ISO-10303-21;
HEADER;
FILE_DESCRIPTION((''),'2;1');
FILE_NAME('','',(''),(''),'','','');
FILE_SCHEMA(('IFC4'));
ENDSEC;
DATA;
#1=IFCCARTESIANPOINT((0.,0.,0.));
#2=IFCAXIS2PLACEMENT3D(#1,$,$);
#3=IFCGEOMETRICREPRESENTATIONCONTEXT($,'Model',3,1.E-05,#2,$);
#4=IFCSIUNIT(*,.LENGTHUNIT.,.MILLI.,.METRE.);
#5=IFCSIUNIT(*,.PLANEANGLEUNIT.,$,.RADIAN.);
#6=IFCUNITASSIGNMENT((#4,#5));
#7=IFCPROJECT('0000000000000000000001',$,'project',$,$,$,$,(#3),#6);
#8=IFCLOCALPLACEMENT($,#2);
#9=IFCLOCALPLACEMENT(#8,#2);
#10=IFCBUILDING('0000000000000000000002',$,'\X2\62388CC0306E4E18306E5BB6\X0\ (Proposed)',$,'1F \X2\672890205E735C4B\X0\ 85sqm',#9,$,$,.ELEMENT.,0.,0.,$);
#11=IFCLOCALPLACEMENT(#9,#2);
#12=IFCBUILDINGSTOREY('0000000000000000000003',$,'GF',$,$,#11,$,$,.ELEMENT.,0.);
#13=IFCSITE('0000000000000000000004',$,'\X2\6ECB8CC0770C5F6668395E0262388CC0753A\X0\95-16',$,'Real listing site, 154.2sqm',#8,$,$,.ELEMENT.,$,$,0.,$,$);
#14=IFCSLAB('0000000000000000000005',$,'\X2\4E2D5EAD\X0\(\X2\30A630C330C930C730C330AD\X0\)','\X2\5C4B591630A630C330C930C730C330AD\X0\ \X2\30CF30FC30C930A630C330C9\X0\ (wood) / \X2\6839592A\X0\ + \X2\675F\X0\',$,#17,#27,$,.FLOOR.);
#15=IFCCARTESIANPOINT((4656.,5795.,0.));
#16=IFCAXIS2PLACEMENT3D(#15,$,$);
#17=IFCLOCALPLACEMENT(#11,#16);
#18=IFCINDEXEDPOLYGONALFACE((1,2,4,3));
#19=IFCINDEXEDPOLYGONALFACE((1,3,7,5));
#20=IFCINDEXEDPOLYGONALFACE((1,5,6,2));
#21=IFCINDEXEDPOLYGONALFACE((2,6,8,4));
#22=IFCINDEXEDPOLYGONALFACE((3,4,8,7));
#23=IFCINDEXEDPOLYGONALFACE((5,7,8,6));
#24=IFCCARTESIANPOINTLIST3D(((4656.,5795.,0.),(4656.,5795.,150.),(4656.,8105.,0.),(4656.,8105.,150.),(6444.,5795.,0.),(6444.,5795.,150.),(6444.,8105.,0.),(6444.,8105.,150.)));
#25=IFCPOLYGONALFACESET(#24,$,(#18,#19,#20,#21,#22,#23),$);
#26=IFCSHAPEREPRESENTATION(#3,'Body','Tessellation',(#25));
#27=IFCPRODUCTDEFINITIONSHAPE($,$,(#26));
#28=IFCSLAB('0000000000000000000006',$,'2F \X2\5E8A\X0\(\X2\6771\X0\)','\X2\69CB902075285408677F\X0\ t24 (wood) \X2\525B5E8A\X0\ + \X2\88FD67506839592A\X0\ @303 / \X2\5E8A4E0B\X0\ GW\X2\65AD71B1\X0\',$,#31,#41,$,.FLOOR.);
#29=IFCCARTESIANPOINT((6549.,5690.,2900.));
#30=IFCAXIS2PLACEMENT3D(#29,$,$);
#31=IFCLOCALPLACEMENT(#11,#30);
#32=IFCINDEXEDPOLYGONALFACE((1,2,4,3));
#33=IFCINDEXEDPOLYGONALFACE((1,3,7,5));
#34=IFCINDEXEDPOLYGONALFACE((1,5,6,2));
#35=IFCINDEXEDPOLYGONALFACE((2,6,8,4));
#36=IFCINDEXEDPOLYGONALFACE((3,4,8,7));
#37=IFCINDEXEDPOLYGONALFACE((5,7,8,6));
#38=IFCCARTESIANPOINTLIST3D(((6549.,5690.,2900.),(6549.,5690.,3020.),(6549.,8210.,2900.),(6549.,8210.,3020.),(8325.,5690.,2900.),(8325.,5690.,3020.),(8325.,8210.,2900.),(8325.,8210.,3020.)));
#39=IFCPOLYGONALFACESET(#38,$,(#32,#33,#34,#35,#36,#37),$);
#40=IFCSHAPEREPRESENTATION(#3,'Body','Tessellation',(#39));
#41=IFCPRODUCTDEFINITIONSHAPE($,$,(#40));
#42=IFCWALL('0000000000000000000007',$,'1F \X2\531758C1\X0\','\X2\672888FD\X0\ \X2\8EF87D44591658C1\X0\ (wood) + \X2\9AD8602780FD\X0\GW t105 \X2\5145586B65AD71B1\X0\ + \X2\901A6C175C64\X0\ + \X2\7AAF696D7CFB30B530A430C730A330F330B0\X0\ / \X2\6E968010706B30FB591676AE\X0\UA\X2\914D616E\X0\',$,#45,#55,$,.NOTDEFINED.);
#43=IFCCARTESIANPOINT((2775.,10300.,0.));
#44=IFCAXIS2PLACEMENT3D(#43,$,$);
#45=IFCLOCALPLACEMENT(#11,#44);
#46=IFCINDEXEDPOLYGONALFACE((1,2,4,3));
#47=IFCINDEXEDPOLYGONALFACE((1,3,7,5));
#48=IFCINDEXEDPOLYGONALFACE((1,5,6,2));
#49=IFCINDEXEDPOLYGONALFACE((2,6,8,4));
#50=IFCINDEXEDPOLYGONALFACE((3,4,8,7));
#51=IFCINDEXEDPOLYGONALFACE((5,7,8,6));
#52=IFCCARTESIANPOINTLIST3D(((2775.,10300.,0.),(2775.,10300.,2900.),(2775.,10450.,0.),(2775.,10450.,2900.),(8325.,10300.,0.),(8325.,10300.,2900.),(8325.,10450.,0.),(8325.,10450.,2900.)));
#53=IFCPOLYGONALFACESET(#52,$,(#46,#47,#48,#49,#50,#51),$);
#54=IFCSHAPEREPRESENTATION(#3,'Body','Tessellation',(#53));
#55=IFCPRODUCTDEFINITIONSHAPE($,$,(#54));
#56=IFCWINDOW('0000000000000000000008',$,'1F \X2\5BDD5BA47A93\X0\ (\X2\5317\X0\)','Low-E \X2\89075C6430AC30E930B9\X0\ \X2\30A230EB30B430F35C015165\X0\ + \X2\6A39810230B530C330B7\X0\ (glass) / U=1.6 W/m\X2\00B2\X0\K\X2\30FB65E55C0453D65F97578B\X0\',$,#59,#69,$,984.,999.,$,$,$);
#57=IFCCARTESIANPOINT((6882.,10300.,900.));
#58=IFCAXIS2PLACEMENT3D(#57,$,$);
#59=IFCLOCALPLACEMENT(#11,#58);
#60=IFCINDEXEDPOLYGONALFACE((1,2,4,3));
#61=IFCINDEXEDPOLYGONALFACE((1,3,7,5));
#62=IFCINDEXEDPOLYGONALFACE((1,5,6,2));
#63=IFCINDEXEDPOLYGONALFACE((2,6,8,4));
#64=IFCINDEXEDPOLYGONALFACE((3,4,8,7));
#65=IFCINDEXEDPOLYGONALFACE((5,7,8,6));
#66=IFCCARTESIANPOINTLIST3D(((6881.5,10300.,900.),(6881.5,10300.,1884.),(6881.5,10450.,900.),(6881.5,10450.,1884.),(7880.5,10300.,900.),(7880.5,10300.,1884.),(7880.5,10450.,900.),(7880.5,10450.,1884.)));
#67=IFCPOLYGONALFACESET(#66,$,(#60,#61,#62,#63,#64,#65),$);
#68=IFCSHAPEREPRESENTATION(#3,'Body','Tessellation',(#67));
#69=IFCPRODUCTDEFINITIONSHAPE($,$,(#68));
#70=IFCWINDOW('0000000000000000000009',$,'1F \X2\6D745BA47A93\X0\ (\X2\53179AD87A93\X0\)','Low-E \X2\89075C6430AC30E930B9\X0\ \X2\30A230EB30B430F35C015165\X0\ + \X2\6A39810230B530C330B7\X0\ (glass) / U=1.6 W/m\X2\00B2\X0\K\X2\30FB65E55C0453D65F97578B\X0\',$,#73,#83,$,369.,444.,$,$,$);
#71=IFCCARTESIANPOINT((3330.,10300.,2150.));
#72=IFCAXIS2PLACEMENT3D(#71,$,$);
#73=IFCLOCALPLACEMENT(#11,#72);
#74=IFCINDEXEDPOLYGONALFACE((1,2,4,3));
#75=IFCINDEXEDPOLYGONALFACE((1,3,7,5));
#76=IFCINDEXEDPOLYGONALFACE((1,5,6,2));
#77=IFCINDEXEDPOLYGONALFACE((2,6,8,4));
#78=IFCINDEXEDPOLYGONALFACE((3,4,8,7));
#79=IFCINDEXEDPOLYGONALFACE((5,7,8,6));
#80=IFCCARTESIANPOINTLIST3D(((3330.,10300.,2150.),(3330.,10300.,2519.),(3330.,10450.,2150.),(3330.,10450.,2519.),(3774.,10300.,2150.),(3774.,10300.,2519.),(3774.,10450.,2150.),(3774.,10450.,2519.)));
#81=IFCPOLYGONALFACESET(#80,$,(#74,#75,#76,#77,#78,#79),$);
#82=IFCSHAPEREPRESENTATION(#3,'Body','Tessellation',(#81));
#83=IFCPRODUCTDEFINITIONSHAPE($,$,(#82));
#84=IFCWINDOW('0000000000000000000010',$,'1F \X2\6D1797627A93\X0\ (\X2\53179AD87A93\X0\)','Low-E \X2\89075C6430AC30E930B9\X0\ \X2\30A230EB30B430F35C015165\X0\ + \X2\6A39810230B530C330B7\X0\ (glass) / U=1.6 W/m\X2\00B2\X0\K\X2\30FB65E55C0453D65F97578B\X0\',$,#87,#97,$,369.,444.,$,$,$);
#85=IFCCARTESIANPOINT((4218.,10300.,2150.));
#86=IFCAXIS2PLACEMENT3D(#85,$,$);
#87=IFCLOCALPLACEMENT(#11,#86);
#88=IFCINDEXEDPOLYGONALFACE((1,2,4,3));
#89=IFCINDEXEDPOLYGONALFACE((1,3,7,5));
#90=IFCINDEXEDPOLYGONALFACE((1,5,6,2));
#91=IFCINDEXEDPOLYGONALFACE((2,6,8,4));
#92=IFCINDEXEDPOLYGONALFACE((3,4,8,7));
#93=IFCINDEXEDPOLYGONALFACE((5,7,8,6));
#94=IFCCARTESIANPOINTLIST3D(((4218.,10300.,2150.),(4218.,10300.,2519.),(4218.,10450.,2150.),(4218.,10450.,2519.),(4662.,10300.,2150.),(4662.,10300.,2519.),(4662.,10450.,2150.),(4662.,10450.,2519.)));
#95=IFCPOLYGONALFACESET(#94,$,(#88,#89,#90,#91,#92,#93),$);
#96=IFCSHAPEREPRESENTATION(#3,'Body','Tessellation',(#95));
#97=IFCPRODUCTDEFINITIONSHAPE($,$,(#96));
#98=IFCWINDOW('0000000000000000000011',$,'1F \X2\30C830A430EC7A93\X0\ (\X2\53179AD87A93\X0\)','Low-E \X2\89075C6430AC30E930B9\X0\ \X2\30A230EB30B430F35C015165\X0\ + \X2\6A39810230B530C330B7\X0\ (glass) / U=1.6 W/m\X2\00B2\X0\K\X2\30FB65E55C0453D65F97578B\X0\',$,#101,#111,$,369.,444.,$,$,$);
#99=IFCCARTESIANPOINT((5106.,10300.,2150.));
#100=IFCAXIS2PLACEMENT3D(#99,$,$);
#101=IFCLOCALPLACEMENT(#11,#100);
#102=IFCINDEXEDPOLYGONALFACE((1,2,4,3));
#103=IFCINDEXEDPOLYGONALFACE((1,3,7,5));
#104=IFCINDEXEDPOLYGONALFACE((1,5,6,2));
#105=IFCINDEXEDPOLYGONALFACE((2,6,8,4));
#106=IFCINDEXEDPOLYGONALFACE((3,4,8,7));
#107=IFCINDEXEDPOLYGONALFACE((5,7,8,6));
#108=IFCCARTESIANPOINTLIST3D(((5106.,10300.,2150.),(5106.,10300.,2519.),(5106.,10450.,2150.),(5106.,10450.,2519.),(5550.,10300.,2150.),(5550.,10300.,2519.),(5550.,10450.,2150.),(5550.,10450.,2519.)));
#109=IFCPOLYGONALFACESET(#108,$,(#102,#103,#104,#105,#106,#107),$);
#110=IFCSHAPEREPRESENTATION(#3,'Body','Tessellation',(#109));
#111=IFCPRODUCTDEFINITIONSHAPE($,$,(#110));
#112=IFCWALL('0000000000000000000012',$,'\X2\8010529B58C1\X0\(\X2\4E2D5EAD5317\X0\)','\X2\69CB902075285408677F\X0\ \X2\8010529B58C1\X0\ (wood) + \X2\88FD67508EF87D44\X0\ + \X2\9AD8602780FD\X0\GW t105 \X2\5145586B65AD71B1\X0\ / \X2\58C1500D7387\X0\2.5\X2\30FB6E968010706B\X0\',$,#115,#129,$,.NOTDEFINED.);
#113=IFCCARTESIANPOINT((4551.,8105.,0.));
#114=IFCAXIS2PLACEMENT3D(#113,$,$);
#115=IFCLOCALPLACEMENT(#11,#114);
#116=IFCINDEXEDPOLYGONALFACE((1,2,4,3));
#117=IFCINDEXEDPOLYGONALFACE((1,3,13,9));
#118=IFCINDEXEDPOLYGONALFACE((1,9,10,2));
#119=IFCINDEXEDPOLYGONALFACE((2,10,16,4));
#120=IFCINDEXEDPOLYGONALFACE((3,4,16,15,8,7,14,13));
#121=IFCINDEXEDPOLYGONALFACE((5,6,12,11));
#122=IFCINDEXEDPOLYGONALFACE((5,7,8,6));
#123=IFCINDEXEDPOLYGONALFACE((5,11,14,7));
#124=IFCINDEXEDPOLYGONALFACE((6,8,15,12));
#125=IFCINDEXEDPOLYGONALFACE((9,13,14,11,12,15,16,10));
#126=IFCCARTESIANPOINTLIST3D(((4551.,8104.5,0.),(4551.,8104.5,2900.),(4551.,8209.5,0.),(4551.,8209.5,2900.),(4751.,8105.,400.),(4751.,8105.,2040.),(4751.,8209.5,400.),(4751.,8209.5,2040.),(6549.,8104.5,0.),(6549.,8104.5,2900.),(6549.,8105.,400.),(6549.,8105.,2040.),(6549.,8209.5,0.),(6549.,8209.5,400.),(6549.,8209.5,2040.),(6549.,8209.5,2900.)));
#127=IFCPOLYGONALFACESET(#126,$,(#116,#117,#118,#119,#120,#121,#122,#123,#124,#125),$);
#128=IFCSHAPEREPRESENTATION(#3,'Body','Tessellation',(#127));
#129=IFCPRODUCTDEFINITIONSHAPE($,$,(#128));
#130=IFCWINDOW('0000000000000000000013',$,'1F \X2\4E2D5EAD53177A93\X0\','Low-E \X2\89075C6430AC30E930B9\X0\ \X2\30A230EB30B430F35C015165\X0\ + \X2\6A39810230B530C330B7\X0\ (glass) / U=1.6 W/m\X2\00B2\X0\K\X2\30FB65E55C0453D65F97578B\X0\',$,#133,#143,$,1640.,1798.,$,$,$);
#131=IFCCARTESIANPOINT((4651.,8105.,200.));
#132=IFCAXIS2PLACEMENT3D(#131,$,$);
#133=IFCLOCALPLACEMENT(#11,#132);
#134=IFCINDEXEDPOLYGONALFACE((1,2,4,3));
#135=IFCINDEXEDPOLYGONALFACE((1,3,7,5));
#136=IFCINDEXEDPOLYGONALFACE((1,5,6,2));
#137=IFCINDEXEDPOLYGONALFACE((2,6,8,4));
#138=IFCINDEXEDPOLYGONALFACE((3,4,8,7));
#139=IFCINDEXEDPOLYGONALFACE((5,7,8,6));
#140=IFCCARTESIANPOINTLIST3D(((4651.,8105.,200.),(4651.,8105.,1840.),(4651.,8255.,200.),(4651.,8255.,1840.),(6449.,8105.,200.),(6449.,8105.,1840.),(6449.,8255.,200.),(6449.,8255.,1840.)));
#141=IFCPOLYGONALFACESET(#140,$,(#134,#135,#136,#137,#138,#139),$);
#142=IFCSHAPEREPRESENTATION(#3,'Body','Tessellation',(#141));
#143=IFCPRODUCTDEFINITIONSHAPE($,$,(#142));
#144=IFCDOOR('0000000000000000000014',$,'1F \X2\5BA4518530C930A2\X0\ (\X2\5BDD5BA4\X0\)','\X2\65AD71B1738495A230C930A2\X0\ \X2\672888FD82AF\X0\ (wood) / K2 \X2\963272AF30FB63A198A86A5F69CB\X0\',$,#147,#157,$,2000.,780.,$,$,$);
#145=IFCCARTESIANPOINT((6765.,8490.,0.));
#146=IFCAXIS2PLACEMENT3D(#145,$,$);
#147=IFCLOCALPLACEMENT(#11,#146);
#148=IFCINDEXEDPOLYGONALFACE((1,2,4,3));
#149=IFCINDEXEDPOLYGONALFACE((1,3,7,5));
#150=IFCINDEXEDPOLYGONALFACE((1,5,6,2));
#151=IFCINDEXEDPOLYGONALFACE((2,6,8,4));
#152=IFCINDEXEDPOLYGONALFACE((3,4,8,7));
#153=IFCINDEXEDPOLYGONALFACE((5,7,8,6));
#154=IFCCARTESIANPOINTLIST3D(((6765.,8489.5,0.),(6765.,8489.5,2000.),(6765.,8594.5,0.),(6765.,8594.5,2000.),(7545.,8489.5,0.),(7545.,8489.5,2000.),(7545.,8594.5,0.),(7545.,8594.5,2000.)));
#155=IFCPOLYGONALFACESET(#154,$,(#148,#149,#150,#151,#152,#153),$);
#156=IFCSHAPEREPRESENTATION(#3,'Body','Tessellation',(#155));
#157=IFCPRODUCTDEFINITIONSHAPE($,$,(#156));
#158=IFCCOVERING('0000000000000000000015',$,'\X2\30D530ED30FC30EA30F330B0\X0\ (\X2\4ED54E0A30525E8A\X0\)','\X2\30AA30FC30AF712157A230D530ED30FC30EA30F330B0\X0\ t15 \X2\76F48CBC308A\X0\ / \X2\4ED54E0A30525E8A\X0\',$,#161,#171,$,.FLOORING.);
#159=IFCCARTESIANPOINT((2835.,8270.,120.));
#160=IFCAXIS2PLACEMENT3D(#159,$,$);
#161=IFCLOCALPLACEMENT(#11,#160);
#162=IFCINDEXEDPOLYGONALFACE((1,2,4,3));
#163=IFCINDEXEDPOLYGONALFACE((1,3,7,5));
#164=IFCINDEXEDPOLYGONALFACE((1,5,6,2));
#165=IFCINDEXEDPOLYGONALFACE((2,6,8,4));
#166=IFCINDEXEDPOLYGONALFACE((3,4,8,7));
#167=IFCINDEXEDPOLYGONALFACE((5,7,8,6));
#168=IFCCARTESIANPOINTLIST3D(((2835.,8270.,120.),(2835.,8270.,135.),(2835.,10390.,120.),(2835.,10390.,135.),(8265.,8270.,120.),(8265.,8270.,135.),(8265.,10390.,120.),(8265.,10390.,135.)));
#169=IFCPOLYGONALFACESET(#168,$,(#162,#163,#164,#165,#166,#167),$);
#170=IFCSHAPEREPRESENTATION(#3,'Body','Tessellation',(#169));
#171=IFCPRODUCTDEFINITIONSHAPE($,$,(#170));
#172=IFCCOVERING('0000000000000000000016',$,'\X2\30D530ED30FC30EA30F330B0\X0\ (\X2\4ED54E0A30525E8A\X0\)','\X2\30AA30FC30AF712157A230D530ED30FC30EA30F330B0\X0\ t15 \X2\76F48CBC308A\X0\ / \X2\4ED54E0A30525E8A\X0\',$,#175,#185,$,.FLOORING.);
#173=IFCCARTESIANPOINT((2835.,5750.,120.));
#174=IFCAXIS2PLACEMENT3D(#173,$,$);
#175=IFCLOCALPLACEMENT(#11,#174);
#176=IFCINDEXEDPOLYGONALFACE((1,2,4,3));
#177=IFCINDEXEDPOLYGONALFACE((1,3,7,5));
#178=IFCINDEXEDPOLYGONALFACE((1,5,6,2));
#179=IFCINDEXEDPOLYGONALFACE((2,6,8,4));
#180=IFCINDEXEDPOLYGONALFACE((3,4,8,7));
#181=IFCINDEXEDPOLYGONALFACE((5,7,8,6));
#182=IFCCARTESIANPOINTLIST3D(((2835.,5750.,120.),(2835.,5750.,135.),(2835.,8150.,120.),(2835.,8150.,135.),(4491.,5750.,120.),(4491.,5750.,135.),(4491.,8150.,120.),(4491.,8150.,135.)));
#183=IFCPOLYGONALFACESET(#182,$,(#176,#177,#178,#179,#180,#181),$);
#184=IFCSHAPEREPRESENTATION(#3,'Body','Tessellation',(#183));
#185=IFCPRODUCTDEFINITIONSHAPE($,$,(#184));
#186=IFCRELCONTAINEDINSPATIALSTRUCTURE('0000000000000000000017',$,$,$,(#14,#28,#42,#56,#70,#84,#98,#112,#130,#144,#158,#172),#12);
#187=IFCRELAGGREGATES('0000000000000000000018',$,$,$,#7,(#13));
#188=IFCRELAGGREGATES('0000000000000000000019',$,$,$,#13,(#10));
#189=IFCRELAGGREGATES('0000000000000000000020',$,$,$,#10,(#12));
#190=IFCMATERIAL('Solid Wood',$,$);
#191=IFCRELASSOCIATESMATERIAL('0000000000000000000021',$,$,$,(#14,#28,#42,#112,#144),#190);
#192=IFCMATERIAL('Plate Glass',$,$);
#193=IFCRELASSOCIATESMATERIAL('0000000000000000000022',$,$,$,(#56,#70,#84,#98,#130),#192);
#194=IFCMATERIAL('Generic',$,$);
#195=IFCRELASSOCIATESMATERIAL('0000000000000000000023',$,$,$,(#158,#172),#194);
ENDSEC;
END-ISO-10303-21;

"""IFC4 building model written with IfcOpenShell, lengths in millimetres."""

from ifc_helpers import new_model, si_unit, frame, frame_2d, origin, place, context, project, spatial, rectangle, extrude, material, element, fill, save


model = new_model("IFC4")

# Units and contexts
model_context = context("Model", 3, precision=1e-05, world=origin())
ifc_project = project(units=[si_unit("LENGTHUNIT", "METRE", prefix="MILLI"), si_unit("PLANEANGLEUNIT", "RADIAN")], contexts=[model_context])

# Site, building, storey
site_placement = place(None, origin())
site = spatial("IfcSite", under=ifc_project, at=site_placement, Name="滋賀県彦根市戸賀町95-16", ObjectType="Real listing site, 154.2sqm", CompositionType="ELEMENT", RefElevation=0.0)
building_placement = place(site_placement, origin())
building = spatial("IfcBuilding", under=site, at=building_placement, Name="戸賀の丘の家 (Proposed)", ObjectType="1F 木造平屋 85sqm", CompositionType="ELEMENT", ElevationOfRefHeight=0.0, ElevationOfTerrain=0.0)
storey_placement = place(building_placement, origin())
storey = spatial("IfcBuildingStorey", under=building, at=storey_placement, Name="GF", CompositionType="ELEMENT", Elevation=0.0)

# Slabs
ifc_material_1 = material(Name="Solid Wood")
slab_1_placement = place(storey_placement, frame((4656.0, 5795.0, 0.0)))
element("IfcSlab", 1, at=slab_1_placement, inside=storey, material=ifc_material_1, Name="中庭(ウッドデッキ)", Description="屋外ウッドデッキ ハードウッド (wood) / 根太 + 束", PredefinedType="FLOOR", context=model_context, shape_type="SweptSolid", body=[
    extrude(rectangle(XDim=1788.0, YDim=2310.0, at=frame_2d((894.0, 1155.0))), frame((4656.0, 5795.0, 0.0)), (0.0, 0.0, 1.0), 150.0),
])
slab_2_placement = place(storey_placement, frame((6549.0, 5690.0, 2900.0)))
element("IfcSlab", 2, at=slab_2_placement, inside=storey, material=ifc_material_1, Name="2F 床(東)", Description="構造用合板 t24 (wood) 剛床 + 製材根太 @303 / 床下 GW断熱", PredefinedType="FLOOR", context=model_context, shape_type="SweptSolid", body=[
    extrude(rectangle(XDim=1776.0, YDim=2520.0, at=frame_2d((888.0, 1260.0))), frame((6549.0, 5690.0, 2900.0)), (0.0, 0.0, 1.0), 120.0),
])

# Wall, openings, windows
wall_1_placement = place(storey_placement, frame((2775.0, 10300.0, 0.0)))
wall_1 = element("IfcWall", 3, at=wall_1_placement, inside=storey, material=ifc_material_1, Name="1F 北壁", Description="木製 軸組外壁 (wood) + 高性能GW t105 充填断熱 + 通気層 + 窯業系サイディング / 準耐火・外皮UA配慮", PredefinedType="NOTDEFINED", context=model_context, shape_type="SweptSolid", body=[
    extrude(rectangle(XDim=5550.0, YDim=150.0, at=frame_2d((2775.0, 75.0))), frame((2775.0, 10300.0, 0.0)), (0.0, 0.0, 1.0), 2900.0),
])
opening_1_placement = place(storey_placement, frame((6882.0, 10300.0, 900.0)))
opening_1 = element("IfcOpeningElement", 4, at=opening_1_placement, cuts=wall_1, PredefinedType="NOTDEFINED", context=model_context, shape_type="SweptSolid", body=[
    extrude(rectangle(XDim=999.0, YDim=150.0, at=frame_2d((499.0, 75.0))), frame((6882.0, 10300.0, 900.0)), (0.0, 0.0, 1.0), 984.0),
])
opening_2_placement = place(storey_placement, frame((3330.0, 10300.0, 2150.0)))
opening_2 = element("IfcOpeningElement", 5, at=opening_2_placement, cuts=wall_1, PredefinedType="NOTDEFINED", context=model_context, shape_type="SweptSolid", body=[
    extrude(rectangle(XDim=444.0, YDim=150.0, at=frame_2d((222.0, 75.0))), frame((3330.0, 10300.0, 2150.0)), (0.0, 0.0, 1.0), 369.0),
])
opening_3_placement = place(storey_placement, frame((4218.0, 10300.0, 2150.0)))
opening_3 = element("IfcOpeningElement", 6, at=opening_3_placement, cuts=wall_1, PredefinedType="NOTDEFINED", context=model_context, shape_type="SweptSolid", body=[
    extrude(rectangle(XDim=444.0, YDim=150.0, at=frame_2d((222.0, 75.0))), frame((4218.0, 10300.0, 2150.0)), (0.0, 0.0, 1.0), 369.0),
])
opening_4_placement = place(storey_placement, frame((5106.0, 10300.0, 2150.0)))
opening_4 = element("IfcOpeningElement", 7, at=opening_4_placement, cuts=wall_1, PredefinedType="NOTDEFINED", context=model_context, shape_type="SweptSolid", body=[
    extrude(rectangle(XDim=444.0, YDim=150.0, at=frame_2d((222.0, 75.0))), frame((5106.0, 10300.0, 2150.0)), (0.0, 0.0, 1.0), 369.0),
])
ifc_material_2 = material(Name="Plate Glass")
window_1_placement = place(storey_placement, frame((6882.0, 10300.0, 900.0)))
window_1 = element("IfcWindow", 8, at=window_1_placement, inside=storey, material=ifc_material_2, Name="1F 寝室窓 (北)", Description="Low-E 複層ガラス アルゴン封入 + 樹脂サッシ (glass) / U=1.6 W/m²K・日射取得型", OverallHeight=984.0, OverallWidth=999.0, context=model_context, shape_type="SweptSolid", body=[
    extrude(rectangle(XDim=999.0, YDim=150.0, at=frame_2d((499.0, 75.0))), frame((6882.0, 10300.0, 900.0)), (0.0, 0.0, 1.0), 984.0),
])
fill(opening_1, window_1)
window_2_placement = place(storey_placement, frame((3330.0, 10300.0, 2150.0)))
window_2 = element("IfcWindow", 9, at=window_2_placement, inside=storey, material=ifc_material_2, Name="1F 浴室窓 (北高窓)", Description="Low-E 複層ガラス アルゴン封入 + 樹脂サッシ (glass) / U=1.6 W/m²K・日射取得型", OverallHeight=369.0, OverallWidth=444.0, context=model_context, shape_type="SweptSolid", body=[
    extrude(rectangle(XDim=444.0, YDim=150.0, at=frame_2d((222.0, 75.0))), frame((3330.0, 10300.0, 2150.0)), (0.0, 0.0, 1.0), 369.0),
])
fill(opening_2, window_2)
window_3_placement = place(storey_placement, frame((4218.0, 10300.0, 2150.0)))
window_3 = element("IfcWindow", 10, at=window_3_placement, inside=storey, material=ifc_material_2, Name="1F 洗面窓 (北高窓)", Description="Low-E 複層ガラス アルゴン封入 + 樹脂サッシ (glass) / U=1.6 W/m²K・日射取得型", OverallHeight=369.0, OverallWidth=444.0, context=model_context, shape_type="SweptSolid", body=[
    extrude(rectangle(XDim=444.0, YDim=150.0, at=frame_2d((222.0, 75.0))), frame((4218.0, 10300.0, 2150.0)), (0.0, 0.0, 1.0), 369.0),
])
fill(opening_3, window_3)
window_4_placement = place(storey_placement, frame((5106.0, 10300.0, 2150.0)))
window_4 = element("IfcWindow", 11, at=window_4_placement, inside=storey, material=ifc_material_2, Name="1F トイレ窓 (北高窓)", Description="Low-E 複層ガラス アルゴン封入 + 樹脂サッシ (glass) / U=1.6 W/m²K・日射取得型", OverallHeight=369.0, OverallWidth=444.0, context=model_context, shape_type="SweptSolid", body=[
    extrude(rectangle(XDim=444.0, YDim=150.0, at=frame_2d((222.0, 75.0))), frame((5106.0, 10300.0, 2150.0)), (0.0, 0.0, 1.0), 369.0),
])
fill(opening_4, window_4)

# Wall, opening, window
wall_2_placement = place(storey_placement, frame((4551.0, 8105.0, 0.0)))
wall_2 = element("IfcWall", 12, at=wall_2_placement, inside=storey, material=ifc_material_1, Name="耐力壁(中庭北)", Description="構造用合板 耐力壁 (wood) + 製材軸組 + 高性能GW t105 充填断熱 / 壁倍率2.5・準耐火", PredefinedType="NOTDEFINED", context=model_context, shape_type="SweptSolid", body=[
    extrude(rectangle(XDim=1998.0, YDim=105.0, at=frame_2d((999.0, 52.0))), frame((4551.0, 8105.0, 0.0)), (0.0, 0.0, 1.0), 2900.0),
])
opening_5_placement = place(storey_placement, frame((4651.0, 8105.0, 200.0)))
opening_5 = element("IfcOpeningElement", 13, at=opening_5_placement, cuts=wall_2, PredefinedType="NOTDEFINED", context=model_context, shape_type="SweptSolid", body=[
    extrude(rectangle(XDim=1798.0, YDim=150.0, at=frame_2d((899.0, 75.0))), frame((4651.0, 8105.0, 200.0)), (0.0, 0.0, 1.0), 1640.0),
])
window_5_placement = place(storey_placement, frame((4651.0, 8105.0, 200.0)))
window_5 = element("IfcWindow", 14, at=window_5_placement, inside=storey, material=ifc_material_2, Name="1F 中庭北窓", Description="Low-E 複層ガラス アルゴン封入 + 樹脂サッシ (glass) / U=1.6 W/m²K・日射取得型", OverallHeight=1640.0, OverallWidth=1798.0, context=model_context, shape_type="SweptSolid", body=[
    extrude(rectangle(XDim=1798.0, YDim=150.0, at=frame_2d((899.0, 75.0))), frame((4651.0, 8105.0, 200.0)), (0.0, 0.0, 1.0), 1640.0),
])
fill(opening_5, window_5)

# Door
door_1_placement = place(storey_placement, frame((6765.0, 8490.0, 0.0)))
element("IfcDoor", 15, at=door_1_placement, inside=storey, material=ifc_material_1, Name="1F 室内ドア (寝室)", Description="断熱玄関ドア 木製芯 (wood) / K2 防犯・採風機構", OverallHeight=2000.0, OverallWidth=780.0, context=model_context, shape_type="SweptSolid", body=[
    extrude(rectangle(XDim=780.0, YDim=105.0, at=frame_2d((390.0, 52.0))), frame((6765.0, 8490.0, 0.0)), (0.0, 0.0, 1.0), 2000.0),
])

# Coverings
ifc_material_3 = material(Name="Generic")
covering_1_placement = place(storey_placement, frame((2835.0, 8270.0, 120.0)))
element("IfcCovering", 16, at=covering_1_placement, inside=storey, material=ifc_material_3, Name="フローリング (仕上げ床)", Description="オーク無垢フローリング t15 直貼り / 仕上げ床", PredefinedType="FLOORING", context=model_context, shape_type="SweptSolid", body=[
    extrude(rectangle(XDim=5430.0, YDim=2120.0, at=frame_2d((2715.0, 1060.0))), frame((2835.0, 8270.0, 120.0)), (0.0, 0.0, 1.0), 15.0),
])
covering_2_placement = place(storey_placement, frame((2835.0, 5750.0, 120.0)))
element("IfcCovering", 17, at=covering_2_placement, inside=storey, material=ifc_material_3, Name="フローリング (仕上げ床)", Description="オーク無垢フローリング t15 直貼り / 仕上げ床", PredefinedType="FLOORING", context=model_context, shape_type="SweptSolid", body=[
    extrude(rectangle(XDim=1656.0, YDim=2400.0, at=frame_2d((828.0, 1200.0))), frame((2835.0, 5750.0, 120.0)), (0.0, 0.0, 1.0), 15.0),
])

save(model, "model.ifc")
